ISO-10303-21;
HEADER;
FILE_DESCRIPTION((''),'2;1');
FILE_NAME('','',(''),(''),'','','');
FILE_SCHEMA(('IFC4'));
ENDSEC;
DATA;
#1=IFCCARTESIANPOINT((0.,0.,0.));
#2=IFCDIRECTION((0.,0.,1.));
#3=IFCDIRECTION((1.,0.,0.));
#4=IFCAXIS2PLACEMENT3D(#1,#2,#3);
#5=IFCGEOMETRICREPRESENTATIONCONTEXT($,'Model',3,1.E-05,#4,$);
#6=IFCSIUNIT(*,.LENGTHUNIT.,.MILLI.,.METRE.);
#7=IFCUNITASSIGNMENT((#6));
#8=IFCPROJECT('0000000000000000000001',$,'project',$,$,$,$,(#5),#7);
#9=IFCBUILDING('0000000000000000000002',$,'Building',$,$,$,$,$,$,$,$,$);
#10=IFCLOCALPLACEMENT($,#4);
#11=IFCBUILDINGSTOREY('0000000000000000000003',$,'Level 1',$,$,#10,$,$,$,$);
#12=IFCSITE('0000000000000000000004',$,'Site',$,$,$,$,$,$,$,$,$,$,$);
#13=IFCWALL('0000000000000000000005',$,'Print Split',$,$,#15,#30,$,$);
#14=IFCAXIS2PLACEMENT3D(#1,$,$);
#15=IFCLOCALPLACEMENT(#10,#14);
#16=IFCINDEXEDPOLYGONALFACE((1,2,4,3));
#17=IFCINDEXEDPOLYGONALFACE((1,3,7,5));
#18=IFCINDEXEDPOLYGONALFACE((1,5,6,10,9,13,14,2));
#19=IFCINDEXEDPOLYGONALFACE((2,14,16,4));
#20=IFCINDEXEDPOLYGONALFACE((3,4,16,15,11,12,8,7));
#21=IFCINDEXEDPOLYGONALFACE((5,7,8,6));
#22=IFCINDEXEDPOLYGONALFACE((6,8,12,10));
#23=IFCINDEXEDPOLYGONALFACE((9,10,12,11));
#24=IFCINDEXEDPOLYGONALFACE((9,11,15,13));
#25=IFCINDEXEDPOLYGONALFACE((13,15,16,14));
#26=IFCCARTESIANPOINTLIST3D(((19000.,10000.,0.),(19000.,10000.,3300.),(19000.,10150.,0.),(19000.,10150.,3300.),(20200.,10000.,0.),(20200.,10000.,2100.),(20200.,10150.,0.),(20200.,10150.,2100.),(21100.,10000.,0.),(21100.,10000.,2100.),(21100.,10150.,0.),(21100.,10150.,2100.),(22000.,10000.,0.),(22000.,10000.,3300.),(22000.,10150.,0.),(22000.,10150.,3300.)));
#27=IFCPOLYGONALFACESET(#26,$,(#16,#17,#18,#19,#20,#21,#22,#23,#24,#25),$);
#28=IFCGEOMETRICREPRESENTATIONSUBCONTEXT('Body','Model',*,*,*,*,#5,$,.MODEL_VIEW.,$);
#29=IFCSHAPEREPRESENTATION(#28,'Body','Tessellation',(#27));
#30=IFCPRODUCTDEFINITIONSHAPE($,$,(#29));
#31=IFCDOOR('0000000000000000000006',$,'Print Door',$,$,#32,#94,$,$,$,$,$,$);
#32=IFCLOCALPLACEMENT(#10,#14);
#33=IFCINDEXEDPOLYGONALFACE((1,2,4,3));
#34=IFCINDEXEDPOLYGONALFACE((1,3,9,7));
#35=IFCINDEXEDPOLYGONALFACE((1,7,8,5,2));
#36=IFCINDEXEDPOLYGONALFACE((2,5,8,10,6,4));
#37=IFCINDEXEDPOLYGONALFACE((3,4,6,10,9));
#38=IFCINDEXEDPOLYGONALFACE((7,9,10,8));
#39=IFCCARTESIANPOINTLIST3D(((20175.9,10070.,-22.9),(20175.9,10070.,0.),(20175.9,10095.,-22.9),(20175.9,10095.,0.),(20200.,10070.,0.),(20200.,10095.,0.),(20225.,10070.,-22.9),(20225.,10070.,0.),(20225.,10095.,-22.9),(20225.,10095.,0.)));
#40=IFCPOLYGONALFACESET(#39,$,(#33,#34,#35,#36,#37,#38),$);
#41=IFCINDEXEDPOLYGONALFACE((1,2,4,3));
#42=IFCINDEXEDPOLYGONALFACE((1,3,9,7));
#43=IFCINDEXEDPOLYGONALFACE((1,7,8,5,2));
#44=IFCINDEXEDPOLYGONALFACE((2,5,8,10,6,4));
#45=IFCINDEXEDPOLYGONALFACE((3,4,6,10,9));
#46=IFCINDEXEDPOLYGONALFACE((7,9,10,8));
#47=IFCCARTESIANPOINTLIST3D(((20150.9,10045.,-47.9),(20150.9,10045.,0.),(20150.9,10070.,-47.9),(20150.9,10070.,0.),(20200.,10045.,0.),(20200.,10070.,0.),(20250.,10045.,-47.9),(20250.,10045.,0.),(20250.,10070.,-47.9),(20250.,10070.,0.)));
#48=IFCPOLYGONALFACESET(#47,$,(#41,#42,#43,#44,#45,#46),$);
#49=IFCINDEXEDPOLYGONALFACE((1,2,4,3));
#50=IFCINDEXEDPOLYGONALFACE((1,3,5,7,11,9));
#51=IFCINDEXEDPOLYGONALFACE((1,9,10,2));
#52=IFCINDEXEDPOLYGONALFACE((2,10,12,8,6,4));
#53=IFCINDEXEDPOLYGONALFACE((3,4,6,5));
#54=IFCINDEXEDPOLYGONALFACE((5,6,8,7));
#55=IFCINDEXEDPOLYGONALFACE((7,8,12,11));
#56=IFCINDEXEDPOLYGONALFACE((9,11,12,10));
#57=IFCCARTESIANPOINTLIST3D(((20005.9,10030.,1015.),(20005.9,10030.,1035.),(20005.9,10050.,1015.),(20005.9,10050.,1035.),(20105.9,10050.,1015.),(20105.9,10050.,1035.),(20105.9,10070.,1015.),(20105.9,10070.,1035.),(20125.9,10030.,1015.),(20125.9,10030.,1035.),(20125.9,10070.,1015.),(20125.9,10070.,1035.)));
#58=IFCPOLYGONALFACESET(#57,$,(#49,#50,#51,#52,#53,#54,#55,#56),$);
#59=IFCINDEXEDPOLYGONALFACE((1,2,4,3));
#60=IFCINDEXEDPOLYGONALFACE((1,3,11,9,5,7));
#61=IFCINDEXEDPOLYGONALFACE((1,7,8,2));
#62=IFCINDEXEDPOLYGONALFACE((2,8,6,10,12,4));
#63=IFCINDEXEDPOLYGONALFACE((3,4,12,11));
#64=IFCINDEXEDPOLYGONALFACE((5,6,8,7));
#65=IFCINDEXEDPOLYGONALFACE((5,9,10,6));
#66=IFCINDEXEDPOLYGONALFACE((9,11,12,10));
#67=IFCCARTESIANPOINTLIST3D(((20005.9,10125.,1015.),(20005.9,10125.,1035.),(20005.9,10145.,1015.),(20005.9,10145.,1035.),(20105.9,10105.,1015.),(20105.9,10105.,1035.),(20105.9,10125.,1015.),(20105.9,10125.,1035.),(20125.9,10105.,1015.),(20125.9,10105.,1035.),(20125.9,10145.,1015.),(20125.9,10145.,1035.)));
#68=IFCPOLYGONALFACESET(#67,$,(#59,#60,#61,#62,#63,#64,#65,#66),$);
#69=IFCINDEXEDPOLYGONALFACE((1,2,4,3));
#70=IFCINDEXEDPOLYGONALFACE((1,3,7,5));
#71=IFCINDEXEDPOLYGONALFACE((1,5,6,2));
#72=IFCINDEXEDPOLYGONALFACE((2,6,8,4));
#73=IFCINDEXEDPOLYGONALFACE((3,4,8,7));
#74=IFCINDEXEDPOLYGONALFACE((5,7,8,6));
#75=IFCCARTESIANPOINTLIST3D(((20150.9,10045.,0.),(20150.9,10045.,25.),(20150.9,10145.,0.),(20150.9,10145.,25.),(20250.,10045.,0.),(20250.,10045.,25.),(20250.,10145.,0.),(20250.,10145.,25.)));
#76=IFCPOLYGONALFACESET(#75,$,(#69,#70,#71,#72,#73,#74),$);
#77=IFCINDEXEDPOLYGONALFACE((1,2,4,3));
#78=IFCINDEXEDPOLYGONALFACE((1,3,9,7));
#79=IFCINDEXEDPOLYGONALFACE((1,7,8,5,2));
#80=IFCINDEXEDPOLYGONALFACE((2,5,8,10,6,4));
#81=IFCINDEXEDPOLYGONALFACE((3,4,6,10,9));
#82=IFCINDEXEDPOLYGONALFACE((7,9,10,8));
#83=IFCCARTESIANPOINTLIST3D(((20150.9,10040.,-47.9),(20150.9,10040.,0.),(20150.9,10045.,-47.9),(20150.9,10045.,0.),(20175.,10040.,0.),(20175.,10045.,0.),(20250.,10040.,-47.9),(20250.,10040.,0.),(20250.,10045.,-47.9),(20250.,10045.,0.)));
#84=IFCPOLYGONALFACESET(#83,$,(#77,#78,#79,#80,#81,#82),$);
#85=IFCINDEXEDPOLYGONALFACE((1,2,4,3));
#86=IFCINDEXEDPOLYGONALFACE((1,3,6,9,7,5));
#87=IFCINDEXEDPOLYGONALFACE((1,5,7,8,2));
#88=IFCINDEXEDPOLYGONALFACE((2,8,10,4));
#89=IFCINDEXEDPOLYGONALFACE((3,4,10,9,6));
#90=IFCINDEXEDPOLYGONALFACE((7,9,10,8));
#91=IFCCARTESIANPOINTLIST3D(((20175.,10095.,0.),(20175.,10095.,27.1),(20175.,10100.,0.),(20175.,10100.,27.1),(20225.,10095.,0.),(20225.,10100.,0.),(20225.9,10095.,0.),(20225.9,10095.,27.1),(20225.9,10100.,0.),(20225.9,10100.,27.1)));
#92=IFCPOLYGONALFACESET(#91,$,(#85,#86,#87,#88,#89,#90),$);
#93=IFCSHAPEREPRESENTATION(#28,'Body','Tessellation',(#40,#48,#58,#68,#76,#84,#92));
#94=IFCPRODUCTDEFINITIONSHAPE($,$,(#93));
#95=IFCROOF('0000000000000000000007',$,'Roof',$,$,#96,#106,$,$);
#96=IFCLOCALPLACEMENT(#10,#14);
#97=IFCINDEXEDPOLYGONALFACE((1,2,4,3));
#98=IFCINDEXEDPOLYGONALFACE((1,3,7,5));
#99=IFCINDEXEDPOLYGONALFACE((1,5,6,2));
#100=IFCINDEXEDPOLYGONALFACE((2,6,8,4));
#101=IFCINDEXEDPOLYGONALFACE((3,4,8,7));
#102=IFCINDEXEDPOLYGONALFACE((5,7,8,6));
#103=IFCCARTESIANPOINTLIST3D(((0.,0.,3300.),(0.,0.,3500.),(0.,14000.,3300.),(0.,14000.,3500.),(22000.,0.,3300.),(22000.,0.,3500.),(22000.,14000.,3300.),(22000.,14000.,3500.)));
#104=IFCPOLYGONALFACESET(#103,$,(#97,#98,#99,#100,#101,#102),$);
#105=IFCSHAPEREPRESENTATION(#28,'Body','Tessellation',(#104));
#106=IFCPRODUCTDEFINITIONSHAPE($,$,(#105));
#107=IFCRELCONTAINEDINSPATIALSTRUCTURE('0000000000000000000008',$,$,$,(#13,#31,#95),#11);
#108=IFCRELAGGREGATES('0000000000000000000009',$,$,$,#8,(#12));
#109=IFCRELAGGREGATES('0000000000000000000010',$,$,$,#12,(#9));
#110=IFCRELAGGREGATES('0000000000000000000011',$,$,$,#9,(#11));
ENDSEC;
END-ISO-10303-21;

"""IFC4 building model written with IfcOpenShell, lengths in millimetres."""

from ifc_helpers import new_model, si_unit, frame, origin_with_axes, place, context, subcontext, project, spatial, line, indexed_curve, outline, extrude, element, fill, save


model = new_model("IFC4")

# Units and contexts
model_context = context("Model", 3, precision=1e-05, world=origin_with_axes())
body_context = subcontext(model_context, "Body", "Model", "MODEL_VIEW")
ifc_project = project(units=[si_unit("LENGTHUNIT", "METRE", prefix="MILLI")], contexts=[model_context])

# Site, building, storey
site = spatial("IfcSite", under=ifc_project, Name="Site")
building = spatial("IfcBuilding", under=site, Name="Building")
storey_placement = place(None, origin_with_axes())
storey = spatial("IfcBuildingStorey", under=building, at=storey_placement, Name="Level 1")

# Wall, opening, door
wall_1_placement = place(storey_placement, frame((19000.0, 10000.0, 0.0), z_axis=(0.0, 0.0, 1.0), x_axis=(1.0, 0.0, 0.0)))
wall_1 = element("IfcWall", 1, at=wall_1_placement, inside=storey, Name="Print Split", context=body_context, shape_type="SweptSolid", body=[
    extrude(outline(indexed_curve([(0.0, 0.0), (0.0, 150.0), (3000.0, 150.0), (3000.0, 0.0), (0.0, 0.0)], self_intersect=False)), origin_with_axes(), (0.0, 0.0, 1.0), 3300.0),
])
opening_1_placement = place(wall_1_placement, frame((1200.0, -100.0, 0.0), z_axis=(0.0, 0.0, 1.0), x_axis=(1.0, 0.0, 0.0)))
opening_1 = element("IfcOpeningElement", 2, at=opening_1_placement, cuts=wall_1, context=body_context, shape_type="SweptSolid", body=[
    extrude(outline(indexed_curve([(0.0, 0.0), (0.0, 350.0), (900.0, 350.0), (900.0, 0.0), (0.0, 0.0)], self_intersect=False)), origin_with_axes(), (0.0, 0.0, 1.0), 2100.0),
])
door_1_placement = place(opening_1_placement, frame((0.0, 145.0, 0.0), z_axis=(0.0, 0.0, 1.0), x_axis=(1.0, 0.0, 0.0)))
door_1 = element("IfcDoor", 3, at=door_1_placement, inside=storey, Name="Print Door", context=body_context, shape_type="SweptSolid", body=[
    extrude(outline(indexed_curve([(0.0, 0.0), (0.0, 2.1), (0.9, 2.1), (0.9, 0.0), (-24.1, 0.0), (-24.1, -22.9), (25.0, -22.9), (25.0, 0.0)], segments=[line(1, 2, 3, 4, 5, 6, 7, 8, 1)])), frame((0.0, 25.0, 0.0), z_axis=(0.0, -1.0, 0.0), x_axis=(1.0, 0.0, 0.0)), (0.0, 0.0, -1.0), 25.0),
    extrude(outline(indexed_curve([(0.0, 0.0), (0.0, 2.1), (0.9, 2.1), (0.9, 0.0), (-49.1, 0.0), (-49.1, -47.9), (50.0, -47.9), (50.0, 0.0)], segments=[line(1, 2, 3, 4, 5, 6, 7, 8, 1)])), frame((0.0, 0.0, 0.0), z_axis=(0.0, -1.0, 0.0), x_axis=(1.0, 0.0, 0.0)), (0.0, 0.0, -1.0), 25.0),
    extrude(outline(indexed_curve([(0.0, 0.0), (-49.1, 0.0), (-49.1, 35.0), (0.0, 35.0)], segments=[line(1, 2, 3, 4, 1)])), frame((25.0, 25.0, 25.0), z_axis=(0.0, 0.0, 1.0), x_axis=(1.0, 0.0, 0.0)), (0.0, 0.0, 1.0), -47.9),
    extrude(outline(indexed_curve([(0.0, 0.0), (0.0, -40.0), (-120.0, -40.0), (-120.0, -20.0), (-20.0, -20.0), (-20.0, 0.0)], segments=[line(1, 2, 3, 4, 5, 6, 1)])), frame((-74.1, 25.0, 1015.0), z_axis=(0.0, 0.0, 1.0), x_axis=(1.0, 0.0, 0.0)), (0.0, 0.0, 1.0), 20.0),
    extrude(outline(indexed_curve([(0.0, 0.0), (0.0, 40.0), (-120.0, 40.0), (-120.0, 20.0), (-20.0, 20.0), (-20.0, 0.0)], segments=[line(1, 2, 3, 4, 5, 6, 1)])), frame((-74.1, 60.0, 1015.0), z_axis=(0.0, 0.0, 1.0), x_axis=(1.0, 0.0, 0.0)), (0.0, 0.0, 1.0), 20.0),
    extrude(outline(indexed_curve([(0.0, 0.0), (-99.1, 0.0), (-99.1, 100.0), (0.0, 100.0)], segments=[line(1, 2, 3, 4, 1)])), frame((50.0, 0.0, 0.0), z_axis=(0.0, 0.0, 1.0), x_axis=(1.0, 0.0, 0.0)), (0.0, 0.0, 1.0), 25.0),
    extrude(outline(indexed_curve([(0.0, 0.0), (0.0, 27.1), (50.9, 27.1), (50.9, 0.0), (-24.1, 0.0), (-24.1, -47.9), (75.0, -47.9), (75.0, 0.0)], segments=[line(1, 2, 3, 4, 5, 6, 7, 8, 1)])), frame((-25.0, -5.0, 0.0), z_axis=(0.0, -1.0, 0.0), x_axis=(1.0, 0.0, 0.0)), (0.0, 0.0, -1.0), 5.0),
    extrude(outline(indexed_curve([(0.0, 0.0), (0.0, 27.1), (50.9, 27.1), (50.9, 0.0), (0.9, 0.0), (0.9, -22.9), (50.0, -22.9), (50.0, 0.0)], segments=[line(1, 2, 3, 4, 5, 6, 7, 8, 1)])), frame((-25.0, 50.0, 0.0), z_axis=(0.0, -1.0, 0.0), x_axis=(1.0, 0.0, 0.0)), (0.0, 0.0, -1.0), 5.0),
])
fill(opening_1, door_1)

# Roof
roof_placement = place(storey_placement, frame((0.0, 0.0, 3300.0), z_axis=(0.0, 0.0, 1.0), x_axis=(1.0, 0.0, 0.0)))
element("IfcRoof", 4, at=roof_placement, inside=storey, Name="Roof", context=body_context, shape_type="SweptSolid", body=[
    extrude(outline(indexed_curve([(0.0, 0.0), (22000.0, 0.0), (22000.0, 14000.0), (0.0, 14000.0), (0.0, 0.0)])), None, (0.0, 0.0, 1.0), 200.0),
])

save(model, "model.ifc")
